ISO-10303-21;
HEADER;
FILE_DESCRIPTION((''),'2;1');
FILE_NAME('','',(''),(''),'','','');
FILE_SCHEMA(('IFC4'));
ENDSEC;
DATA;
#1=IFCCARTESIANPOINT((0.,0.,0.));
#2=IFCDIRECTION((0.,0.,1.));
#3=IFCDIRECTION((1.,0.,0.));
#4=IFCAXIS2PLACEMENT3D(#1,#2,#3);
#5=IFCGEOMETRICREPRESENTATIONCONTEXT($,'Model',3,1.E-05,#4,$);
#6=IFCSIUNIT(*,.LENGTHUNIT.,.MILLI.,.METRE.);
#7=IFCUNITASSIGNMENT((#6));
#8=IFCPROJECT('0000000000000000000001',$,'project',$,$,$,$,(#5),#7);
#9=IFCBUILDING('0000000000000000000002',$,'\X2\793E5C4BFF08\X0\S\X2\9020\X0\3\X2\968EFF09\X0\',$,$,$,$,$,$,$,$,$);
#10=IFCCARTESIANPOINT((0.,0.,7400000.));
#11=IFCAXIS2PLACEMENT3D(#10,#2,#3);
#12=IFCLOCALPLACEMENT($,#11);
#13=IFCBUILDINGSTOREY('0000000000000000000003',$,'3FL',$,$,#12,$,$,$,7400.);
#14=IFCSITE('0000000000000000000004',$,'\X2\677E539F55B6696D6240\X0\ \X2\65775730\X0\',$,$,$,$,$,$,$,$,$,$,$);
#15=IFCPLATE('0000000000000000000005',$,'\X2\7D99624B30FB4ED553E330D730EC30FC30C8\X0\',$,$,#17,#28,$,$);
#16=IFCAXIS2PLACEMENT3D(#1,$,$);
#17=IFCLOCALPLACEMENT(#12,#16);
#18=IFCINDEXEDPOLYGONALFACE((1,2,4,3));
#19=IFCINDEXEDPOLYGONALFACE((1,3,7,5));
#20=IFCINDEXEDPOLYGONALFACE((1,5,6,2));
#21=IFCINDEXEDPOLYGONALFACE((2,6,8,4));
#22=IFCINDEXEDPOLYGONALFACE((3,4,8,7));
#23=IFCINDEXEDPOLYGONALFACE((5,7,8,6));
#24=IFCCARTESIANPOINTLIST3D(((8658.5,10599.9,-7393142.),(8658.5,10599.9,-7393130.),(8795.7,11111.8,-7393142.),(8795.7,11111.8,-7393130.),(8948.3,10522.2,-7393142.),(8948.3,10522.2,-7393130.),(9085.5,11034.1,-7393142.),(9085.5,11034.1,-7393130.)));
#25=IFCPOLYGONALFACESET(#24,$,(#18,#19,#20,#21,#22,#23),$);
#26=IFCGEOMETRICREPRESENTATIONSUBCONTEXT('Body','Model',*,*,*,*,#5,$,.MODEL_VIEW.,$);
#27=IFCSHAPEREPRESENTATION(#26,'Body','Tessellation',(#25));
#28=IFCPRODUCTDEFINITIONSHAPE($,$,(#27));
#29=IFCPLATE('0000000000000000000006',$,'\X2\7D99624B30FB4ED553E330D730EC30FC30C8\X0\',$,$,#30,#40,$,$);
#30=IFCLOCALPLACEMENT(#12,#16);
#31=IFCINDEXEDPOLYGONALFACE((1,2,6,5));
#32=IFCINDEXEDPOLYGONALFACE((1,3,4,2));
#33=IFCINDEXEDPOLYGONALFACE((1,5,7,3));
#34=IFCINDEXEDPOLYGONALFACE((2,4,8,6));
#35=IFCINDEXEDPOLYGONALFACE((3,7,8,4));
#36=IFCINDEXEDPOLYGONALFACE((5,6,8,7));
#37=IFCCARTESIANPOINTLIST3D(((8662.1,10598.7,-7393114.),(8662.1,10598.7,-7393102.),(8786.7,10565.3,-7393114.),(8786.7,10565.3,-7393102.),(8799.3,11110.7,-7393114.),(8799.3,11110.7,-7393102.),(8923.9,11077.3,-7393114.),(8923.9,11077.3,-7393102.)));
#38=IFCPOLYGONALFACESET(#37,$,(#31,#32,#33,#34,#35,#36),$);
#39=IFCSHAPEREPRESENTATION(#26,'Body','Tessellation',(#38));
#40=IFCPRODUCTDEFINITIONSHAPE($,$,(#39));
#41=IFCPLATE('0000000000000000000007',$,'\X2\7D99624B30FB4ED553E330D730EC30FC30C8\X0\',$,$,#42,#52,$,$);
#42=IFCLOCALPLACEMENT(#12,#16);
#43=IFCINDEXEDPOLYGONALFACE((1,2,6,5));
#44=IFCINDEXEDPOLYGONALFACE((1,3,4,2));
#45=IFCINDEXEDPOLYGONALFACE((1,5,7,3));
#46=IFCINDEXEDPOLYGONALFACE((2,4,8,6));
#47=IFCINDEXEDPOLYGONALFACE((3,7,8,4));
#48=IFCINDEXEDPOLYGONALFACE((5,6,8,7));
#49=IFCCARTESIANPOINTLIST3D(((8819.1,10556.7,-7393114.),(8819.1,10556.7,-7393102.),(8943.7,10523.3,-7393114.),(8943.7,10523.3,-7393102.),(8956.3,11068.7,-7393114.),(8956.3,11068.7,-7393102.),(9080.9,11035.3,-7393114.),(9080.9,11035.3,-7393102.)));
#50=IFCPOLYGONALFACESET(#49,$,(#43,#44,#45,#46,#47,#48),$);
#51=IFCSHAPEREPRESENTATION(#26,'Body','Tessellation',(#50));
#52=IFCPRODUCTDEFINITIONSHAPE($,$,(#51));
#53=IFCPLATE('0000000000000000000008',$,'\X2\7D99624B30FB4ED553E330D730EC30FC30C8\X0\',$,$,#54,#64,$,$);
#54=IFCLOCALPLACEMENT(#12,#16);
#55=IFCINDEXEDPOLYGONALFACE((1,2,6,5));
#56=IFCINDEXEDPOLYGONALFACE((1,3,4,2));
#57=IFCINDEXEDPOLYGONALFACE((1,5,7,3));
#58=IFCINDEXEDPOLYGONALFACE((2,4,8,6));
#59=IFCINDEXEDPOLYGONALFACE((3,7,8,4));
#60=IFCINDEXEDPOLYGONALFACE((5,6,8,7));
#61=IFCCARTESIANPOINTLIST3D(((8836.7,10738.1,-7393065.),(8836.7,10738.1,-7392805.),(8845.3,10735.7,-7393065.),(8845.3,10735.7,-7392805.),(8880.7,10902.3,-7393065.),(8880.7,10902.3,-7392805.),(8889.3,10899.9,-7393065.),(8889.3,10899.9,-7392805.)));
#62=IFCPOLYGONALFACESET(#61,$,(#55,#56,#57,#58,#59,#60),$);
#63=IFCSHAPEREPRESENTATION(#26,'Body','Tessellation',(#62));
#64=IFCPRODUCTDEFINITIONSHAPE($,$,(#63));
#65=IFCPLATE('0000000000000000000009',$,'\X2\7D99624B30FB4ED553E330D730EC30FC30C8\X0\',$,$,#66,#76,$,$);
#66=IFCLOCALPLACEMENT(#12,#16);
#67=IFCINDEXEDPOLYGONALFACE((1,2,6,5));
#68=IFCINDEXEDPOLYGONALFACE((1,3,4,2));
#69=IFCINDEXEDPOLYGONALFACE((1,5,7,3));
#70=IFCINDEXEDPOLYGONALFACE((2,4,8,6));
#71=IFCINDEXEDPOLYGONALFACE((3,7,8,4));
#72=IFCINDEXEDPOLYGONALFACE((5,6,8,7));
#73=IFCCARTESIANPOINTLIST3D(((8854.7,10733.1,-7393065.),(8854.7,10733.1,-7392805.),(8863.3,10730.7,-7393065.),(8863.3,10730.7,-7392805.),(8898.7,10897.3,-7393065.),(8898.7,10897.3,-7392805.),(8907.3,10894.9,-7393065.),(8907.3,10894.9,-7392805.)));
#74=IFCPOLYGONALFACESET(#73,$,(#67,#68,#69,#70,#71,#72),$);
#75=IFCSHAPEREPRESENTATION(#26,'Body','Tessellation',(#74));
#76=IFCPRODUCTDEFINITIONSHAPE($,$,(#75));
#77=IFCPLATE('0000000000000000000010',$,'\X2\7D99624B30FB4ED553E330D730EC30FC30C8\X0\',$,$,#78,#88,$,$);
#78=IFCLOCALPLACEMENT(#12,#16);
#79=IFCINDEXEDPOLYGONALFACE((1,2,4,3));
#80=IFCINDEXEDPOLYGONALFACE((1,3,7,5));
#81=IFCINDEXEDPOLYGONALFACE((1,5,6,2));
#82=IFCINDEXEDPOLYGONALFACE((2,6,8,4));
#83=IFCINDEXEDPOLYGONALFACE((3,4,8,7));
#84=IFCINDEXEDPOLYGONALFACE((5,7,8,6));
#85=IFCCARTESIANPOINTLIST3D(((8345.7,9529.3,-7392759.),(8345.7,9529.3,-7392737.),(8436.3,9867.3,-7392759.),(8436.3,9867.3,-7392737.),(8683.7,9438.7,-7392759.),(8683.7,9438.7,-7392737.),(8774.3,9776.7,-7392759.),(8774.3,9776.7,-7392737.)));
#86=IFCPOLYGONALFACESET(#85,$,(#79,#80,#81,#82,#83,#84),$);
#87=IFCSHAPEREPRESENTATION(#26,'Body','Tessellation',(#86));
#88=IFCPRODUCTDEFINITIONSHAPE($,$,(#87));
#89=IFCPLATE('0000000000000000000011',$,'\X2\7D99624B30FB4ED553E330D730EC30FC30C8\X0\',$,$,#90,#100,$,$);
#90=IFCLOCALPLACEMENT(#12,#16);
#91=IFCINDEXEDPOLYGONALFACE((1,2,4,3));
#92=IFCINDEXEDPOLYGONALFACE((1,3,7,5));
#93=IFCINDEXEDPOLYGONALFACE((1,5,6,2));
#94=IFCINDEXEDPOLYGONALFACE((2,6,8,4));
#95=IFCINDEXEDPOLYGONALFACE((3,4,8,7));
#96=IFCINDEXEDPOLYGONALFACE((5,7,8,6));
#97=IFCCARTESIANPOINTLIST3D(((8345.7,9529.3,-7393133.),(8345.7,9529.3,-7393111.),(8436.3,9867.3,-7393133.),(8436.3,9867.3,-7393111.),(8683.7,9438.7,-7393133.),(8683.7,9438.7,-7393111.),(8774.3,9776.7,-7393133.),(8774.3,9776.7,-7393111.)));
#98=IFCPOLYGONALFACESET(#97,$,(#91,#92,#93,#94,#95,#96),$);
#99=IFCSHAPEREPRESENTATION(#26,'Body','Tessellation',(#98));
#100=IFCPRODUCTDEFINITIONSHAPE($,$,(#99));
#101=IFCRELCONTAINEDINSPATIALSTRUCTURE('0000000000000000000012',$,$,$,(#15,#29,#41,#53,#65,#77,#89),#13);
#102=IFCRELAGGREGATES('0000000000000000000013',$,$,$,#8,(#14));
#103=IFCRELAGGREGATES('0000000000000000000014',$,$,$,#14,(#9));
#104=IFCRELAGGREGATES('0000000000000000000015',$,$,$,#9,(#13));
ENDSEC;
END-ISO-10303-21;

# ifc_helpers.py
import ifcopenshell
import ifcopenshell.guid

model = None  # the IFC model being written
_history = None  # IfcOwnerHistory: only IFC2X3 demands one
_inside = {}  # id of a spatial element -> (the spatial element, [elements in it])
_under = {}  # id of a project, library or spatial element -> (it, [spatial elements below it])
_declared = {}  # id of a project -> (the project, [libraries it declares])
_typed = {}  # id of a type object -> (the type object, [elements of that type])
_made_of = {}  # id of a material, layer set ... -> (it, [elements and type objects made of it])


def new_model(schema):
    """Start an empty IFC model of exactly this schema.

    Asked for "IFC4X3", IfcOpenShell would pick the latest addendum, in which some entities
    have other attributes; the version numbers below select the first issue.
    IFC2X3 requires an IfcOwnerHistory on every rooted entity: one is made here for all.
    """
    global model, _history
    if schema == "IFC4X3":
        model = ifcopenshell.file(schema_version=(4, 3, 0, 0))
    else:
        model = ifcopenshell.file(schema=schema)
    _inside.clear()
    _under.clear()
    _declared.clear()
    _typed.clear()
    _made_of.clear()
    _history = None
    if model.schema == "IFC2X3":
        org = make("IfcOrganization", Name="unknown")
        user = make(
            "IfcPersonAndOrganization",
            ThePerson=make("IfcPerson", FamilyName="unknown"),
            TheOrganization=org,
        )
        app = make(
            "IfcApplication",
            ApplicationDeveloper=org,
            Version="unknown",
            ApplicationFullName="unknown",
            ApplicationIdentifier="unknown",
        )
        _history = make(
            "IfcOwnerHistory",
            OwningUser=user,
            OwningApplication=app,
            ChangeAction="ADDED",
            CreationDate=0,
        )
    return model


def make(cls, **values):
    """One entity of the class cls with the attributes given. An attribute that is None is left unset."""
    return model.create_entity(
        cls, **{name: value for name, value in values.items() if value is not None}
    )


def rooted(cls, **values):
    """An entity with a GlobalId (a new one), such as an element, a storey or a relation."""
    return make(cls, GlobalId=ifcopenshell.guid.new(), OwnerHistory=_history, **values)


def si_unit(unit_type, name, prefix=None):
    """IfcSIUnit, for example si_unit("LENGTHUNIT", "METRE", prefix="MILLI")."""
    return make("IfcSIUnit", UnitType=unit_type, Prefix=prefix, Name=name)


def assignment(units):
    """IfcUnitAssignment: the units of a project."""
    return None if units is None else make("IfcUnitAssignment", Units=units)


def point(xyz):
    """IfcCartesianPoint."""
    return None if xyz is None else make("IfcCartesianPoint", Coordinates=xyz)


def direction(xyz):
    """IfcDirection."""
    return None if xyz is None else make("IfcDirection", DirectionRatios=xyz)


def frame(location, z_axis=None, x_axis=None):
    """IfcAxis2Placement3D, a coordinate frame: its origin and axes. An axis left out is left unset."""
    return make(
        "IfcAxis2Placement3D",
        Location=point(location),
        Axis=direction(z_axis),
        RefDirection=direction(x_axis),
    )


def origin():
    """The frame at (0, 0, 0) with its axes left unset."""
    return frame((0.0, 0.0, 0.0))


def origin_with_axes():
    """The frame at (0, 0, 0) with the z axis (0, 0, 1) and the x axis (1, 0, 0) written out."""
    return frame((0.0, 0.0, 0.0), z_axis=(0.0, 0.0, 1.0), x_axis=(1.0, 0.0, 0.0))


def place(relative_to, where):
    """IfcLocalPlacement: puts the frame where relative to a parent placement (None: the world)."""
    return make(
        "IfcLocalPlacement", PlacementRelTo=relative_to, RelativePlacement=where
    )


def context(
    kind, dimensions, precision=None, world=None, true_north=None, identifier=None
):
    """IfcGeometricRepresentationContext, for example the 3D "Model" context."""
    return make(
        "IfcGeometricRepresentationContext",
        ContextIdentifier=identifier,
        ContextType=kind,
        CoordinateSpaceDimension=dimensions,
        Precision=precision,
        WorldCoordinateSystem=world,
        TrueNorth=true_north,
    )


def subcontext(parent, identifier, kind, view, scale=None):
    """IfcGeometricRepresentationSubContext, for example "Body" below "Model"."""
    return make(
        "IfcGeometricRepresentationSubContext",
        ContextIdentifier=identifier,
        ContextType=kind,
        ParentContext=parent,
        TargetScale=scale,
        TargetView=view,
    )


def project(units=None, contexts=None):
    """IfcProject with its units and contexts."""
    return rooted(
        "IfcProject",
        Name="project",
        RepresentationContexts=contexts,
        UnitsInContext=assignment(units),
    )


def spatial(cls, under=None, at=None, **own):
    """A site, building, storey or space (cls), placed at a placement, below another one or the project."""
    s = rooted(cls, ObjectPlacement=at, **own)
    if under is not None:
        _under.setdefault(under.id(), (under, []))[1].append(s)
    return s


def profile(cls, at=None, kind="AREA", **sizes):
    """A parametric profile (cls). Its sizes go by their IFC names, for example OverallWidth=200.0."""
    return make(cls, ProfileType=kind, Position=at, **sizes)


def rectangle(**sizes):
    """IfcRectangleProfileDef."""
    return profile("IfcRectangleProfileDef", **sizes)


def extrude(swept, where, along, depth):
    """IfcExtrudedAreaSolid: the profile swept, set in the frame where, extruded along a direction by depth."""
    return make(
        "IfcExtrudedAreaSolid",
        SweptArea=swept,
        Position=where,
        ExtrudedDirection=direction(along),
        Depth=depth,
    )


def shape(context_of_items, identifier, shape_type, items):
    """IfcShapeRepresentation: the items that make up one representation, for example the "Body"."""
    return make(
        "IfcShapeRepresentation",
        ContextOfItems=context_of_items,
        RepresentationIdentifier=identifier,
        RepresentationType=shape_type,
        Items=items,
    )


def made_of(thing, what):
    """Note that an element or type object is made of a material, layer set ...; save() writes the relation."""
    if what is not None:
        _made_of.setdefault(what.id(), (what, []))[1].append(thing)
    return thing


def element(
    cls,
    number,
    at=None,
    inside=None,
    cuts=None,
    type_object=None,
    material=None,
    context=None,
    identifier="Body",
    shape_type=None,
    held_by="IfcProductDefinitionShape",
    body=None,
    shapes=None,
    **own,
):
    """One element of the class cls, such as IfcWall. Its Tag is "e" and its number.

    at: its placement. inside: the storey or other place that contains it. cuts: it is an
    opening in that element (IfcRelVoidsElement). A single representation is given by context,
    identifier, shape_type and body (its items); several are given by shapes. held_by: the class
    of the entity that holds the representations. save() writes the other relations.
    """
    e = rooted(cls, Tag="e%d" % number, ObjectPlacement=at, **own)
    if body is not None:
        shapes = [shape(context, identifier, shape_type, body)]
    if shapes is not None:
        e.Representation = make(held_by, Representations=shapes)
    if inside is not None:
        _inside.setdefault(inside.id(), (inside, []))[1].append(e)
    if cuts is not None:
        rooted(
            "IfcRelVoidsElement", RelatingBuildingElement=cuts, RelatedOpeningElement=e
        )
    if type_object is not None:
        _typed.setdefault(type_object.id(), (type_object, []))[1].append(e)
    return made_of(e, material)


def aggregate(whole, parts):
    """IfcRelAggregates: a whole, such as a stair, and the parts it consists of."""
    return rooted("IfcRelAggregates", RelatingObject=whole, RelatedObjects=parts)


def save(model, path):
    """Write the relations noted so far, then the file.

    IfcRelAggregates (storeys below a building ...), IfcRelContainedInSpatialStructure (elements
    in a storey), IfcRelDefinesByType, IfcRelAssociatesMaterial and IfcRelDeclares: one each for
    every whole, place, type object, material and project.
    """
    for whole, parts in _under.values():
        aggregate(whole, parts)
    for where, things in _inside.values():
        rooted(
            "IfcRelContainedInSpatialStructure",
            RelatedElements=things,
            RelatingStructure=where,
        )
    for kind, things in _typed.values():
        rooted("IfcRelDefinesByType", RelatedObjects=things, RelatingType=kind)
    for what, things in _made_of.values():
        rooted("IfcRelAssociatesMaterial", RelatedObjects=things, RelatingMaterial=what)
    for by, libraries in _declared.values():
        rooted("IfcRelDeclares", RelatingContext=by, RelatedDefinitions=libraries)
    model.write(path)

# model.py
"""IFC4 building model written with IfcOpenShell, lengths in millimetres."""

from ifc_helpers import new_model, si_unit, frame, origin, origin_with_axes, place, context, subcontext, project, spatial, rectangle, extrude, element, save


model = new_model("IFC4")

# Units and contexts
model_context = context("Model", 3, precision=1e-05, world=origin_with_axes())
body_context = subcontext(model_context, "Body", "Model", "MODEL_VIEW")
ifc_project = project(units=[si_unit("LENGTHUNIT", "METRE", prefix="MILLI")], contexts=[model_context])

# Site, building, storey
site = spatial("IfcSite", under=ifc_project, Name="松原営業所 敷地")
building = spatial("IfcBuilding", under=site, Name="社屋（S造3階）")
storey_placement = place(None, frame((0.0, 0.0, 7400000.0), z_axis=(0.0, 0.0, 1.0), x_axis=(1.0, 0.0, 0.0)))
storey = spatial("IfcBuildingStorey", under=building, at=storey_placement, Name="3FL", Elevation=7400.0)

# Plates
plate_1_placement = place(storey_placement, frame((8803.4, 10561.0, -7393136.0), z_axis=(0.258819, 0.965926, 0.0), x_axis=(-0.965926, 0.258819, 0.0)))
element("IfcPlate", 1, at=plate_1_placement, inside=storey, Name="継手・仕口プレート", context=body_context, shape_type="SweptSolid", body=[
    extrude(rectangle(XDim=300.0, YDim=12.0), origin(), (0.0, 0.0, 1.0), 530.0),
])
for number, where, z_axis, x_axis, name in (
    (2, (8724.4, 10582.0, -7393108.0), (0.258819, 0.965926, 0.0), (-0.965926, 0.258819, 0.0), "継手・仕口プレート"),
    (3, (8881.4, 10540.0, -7393108.0), (0.258819, 0.965926, 0.0), (-0.965926, 0.258819, 0.0), "継手・仕口プレート"),
):
    element("IfcPlate", number, at=place(storey_placement, frame(where, z_axis=z_axis, x_axis=x_axis)), inside=storey, Name=name, context=body_context, shape_type="SweptSolid", body=[
        extrude(rectangle(XDim=129.0, YDim=12.0), origin(), (0.0, 0.0, 1.0), 530.0),
    ])
for number, where, z_axis, x_axis, name in (
    (4, (8841.0, 10736.9, -7392935.0), (0.258819, 0.965926, 0.0), (-0.965926, 0.258819, 0.0), "継手・仕口プレート"),
    (5, (8859.0, 10731.9, -7392935.0), (0.258819, 0.965926, 0.0), (-0.965926, 0.258819, 0.0), "継手・仕口プレート"),
):
    element("IfcPlate", number, at=place(storey_placement, frame(where, z_axis=z_axis, x_axis=x_axis)), inside=storey, Name=name, context=body_context, shape_type="SweptSolid", body=[
        extrude(rectangle(XDim=9.0, YDim=260.0), origin(), (0.0, 0.0, 1.0), 170.0),
    ])
for number, where, z_axis, x_axis, name in (
    (6, (8391.0, 9698.3, -7392748.0), (0.965926, -0.258819, 0.0), (0.258819, 0.965926, 0.0), "継手・仕口プレート"),
    (7, (8391.0, 9698.3, -7393122.0), (0.965926, -0.258819, 0.0), (0.258819, 0.965926, 0.0), "継手・仕口プレート"),
):
    element("IfcPlate", number, at=place(storey_placement, frame(where, z_axis=z_axis, x_axis=x_axis)), inside=storey, Name=name, context=body_context, shape_type="SweptSolid", body=[
        extrude(rectangle(XDim=350.0, YDim=22.0), origin(), (0.0, 0.0, 1.0), 350.0),
    ])

save(model, "model.ifc")
